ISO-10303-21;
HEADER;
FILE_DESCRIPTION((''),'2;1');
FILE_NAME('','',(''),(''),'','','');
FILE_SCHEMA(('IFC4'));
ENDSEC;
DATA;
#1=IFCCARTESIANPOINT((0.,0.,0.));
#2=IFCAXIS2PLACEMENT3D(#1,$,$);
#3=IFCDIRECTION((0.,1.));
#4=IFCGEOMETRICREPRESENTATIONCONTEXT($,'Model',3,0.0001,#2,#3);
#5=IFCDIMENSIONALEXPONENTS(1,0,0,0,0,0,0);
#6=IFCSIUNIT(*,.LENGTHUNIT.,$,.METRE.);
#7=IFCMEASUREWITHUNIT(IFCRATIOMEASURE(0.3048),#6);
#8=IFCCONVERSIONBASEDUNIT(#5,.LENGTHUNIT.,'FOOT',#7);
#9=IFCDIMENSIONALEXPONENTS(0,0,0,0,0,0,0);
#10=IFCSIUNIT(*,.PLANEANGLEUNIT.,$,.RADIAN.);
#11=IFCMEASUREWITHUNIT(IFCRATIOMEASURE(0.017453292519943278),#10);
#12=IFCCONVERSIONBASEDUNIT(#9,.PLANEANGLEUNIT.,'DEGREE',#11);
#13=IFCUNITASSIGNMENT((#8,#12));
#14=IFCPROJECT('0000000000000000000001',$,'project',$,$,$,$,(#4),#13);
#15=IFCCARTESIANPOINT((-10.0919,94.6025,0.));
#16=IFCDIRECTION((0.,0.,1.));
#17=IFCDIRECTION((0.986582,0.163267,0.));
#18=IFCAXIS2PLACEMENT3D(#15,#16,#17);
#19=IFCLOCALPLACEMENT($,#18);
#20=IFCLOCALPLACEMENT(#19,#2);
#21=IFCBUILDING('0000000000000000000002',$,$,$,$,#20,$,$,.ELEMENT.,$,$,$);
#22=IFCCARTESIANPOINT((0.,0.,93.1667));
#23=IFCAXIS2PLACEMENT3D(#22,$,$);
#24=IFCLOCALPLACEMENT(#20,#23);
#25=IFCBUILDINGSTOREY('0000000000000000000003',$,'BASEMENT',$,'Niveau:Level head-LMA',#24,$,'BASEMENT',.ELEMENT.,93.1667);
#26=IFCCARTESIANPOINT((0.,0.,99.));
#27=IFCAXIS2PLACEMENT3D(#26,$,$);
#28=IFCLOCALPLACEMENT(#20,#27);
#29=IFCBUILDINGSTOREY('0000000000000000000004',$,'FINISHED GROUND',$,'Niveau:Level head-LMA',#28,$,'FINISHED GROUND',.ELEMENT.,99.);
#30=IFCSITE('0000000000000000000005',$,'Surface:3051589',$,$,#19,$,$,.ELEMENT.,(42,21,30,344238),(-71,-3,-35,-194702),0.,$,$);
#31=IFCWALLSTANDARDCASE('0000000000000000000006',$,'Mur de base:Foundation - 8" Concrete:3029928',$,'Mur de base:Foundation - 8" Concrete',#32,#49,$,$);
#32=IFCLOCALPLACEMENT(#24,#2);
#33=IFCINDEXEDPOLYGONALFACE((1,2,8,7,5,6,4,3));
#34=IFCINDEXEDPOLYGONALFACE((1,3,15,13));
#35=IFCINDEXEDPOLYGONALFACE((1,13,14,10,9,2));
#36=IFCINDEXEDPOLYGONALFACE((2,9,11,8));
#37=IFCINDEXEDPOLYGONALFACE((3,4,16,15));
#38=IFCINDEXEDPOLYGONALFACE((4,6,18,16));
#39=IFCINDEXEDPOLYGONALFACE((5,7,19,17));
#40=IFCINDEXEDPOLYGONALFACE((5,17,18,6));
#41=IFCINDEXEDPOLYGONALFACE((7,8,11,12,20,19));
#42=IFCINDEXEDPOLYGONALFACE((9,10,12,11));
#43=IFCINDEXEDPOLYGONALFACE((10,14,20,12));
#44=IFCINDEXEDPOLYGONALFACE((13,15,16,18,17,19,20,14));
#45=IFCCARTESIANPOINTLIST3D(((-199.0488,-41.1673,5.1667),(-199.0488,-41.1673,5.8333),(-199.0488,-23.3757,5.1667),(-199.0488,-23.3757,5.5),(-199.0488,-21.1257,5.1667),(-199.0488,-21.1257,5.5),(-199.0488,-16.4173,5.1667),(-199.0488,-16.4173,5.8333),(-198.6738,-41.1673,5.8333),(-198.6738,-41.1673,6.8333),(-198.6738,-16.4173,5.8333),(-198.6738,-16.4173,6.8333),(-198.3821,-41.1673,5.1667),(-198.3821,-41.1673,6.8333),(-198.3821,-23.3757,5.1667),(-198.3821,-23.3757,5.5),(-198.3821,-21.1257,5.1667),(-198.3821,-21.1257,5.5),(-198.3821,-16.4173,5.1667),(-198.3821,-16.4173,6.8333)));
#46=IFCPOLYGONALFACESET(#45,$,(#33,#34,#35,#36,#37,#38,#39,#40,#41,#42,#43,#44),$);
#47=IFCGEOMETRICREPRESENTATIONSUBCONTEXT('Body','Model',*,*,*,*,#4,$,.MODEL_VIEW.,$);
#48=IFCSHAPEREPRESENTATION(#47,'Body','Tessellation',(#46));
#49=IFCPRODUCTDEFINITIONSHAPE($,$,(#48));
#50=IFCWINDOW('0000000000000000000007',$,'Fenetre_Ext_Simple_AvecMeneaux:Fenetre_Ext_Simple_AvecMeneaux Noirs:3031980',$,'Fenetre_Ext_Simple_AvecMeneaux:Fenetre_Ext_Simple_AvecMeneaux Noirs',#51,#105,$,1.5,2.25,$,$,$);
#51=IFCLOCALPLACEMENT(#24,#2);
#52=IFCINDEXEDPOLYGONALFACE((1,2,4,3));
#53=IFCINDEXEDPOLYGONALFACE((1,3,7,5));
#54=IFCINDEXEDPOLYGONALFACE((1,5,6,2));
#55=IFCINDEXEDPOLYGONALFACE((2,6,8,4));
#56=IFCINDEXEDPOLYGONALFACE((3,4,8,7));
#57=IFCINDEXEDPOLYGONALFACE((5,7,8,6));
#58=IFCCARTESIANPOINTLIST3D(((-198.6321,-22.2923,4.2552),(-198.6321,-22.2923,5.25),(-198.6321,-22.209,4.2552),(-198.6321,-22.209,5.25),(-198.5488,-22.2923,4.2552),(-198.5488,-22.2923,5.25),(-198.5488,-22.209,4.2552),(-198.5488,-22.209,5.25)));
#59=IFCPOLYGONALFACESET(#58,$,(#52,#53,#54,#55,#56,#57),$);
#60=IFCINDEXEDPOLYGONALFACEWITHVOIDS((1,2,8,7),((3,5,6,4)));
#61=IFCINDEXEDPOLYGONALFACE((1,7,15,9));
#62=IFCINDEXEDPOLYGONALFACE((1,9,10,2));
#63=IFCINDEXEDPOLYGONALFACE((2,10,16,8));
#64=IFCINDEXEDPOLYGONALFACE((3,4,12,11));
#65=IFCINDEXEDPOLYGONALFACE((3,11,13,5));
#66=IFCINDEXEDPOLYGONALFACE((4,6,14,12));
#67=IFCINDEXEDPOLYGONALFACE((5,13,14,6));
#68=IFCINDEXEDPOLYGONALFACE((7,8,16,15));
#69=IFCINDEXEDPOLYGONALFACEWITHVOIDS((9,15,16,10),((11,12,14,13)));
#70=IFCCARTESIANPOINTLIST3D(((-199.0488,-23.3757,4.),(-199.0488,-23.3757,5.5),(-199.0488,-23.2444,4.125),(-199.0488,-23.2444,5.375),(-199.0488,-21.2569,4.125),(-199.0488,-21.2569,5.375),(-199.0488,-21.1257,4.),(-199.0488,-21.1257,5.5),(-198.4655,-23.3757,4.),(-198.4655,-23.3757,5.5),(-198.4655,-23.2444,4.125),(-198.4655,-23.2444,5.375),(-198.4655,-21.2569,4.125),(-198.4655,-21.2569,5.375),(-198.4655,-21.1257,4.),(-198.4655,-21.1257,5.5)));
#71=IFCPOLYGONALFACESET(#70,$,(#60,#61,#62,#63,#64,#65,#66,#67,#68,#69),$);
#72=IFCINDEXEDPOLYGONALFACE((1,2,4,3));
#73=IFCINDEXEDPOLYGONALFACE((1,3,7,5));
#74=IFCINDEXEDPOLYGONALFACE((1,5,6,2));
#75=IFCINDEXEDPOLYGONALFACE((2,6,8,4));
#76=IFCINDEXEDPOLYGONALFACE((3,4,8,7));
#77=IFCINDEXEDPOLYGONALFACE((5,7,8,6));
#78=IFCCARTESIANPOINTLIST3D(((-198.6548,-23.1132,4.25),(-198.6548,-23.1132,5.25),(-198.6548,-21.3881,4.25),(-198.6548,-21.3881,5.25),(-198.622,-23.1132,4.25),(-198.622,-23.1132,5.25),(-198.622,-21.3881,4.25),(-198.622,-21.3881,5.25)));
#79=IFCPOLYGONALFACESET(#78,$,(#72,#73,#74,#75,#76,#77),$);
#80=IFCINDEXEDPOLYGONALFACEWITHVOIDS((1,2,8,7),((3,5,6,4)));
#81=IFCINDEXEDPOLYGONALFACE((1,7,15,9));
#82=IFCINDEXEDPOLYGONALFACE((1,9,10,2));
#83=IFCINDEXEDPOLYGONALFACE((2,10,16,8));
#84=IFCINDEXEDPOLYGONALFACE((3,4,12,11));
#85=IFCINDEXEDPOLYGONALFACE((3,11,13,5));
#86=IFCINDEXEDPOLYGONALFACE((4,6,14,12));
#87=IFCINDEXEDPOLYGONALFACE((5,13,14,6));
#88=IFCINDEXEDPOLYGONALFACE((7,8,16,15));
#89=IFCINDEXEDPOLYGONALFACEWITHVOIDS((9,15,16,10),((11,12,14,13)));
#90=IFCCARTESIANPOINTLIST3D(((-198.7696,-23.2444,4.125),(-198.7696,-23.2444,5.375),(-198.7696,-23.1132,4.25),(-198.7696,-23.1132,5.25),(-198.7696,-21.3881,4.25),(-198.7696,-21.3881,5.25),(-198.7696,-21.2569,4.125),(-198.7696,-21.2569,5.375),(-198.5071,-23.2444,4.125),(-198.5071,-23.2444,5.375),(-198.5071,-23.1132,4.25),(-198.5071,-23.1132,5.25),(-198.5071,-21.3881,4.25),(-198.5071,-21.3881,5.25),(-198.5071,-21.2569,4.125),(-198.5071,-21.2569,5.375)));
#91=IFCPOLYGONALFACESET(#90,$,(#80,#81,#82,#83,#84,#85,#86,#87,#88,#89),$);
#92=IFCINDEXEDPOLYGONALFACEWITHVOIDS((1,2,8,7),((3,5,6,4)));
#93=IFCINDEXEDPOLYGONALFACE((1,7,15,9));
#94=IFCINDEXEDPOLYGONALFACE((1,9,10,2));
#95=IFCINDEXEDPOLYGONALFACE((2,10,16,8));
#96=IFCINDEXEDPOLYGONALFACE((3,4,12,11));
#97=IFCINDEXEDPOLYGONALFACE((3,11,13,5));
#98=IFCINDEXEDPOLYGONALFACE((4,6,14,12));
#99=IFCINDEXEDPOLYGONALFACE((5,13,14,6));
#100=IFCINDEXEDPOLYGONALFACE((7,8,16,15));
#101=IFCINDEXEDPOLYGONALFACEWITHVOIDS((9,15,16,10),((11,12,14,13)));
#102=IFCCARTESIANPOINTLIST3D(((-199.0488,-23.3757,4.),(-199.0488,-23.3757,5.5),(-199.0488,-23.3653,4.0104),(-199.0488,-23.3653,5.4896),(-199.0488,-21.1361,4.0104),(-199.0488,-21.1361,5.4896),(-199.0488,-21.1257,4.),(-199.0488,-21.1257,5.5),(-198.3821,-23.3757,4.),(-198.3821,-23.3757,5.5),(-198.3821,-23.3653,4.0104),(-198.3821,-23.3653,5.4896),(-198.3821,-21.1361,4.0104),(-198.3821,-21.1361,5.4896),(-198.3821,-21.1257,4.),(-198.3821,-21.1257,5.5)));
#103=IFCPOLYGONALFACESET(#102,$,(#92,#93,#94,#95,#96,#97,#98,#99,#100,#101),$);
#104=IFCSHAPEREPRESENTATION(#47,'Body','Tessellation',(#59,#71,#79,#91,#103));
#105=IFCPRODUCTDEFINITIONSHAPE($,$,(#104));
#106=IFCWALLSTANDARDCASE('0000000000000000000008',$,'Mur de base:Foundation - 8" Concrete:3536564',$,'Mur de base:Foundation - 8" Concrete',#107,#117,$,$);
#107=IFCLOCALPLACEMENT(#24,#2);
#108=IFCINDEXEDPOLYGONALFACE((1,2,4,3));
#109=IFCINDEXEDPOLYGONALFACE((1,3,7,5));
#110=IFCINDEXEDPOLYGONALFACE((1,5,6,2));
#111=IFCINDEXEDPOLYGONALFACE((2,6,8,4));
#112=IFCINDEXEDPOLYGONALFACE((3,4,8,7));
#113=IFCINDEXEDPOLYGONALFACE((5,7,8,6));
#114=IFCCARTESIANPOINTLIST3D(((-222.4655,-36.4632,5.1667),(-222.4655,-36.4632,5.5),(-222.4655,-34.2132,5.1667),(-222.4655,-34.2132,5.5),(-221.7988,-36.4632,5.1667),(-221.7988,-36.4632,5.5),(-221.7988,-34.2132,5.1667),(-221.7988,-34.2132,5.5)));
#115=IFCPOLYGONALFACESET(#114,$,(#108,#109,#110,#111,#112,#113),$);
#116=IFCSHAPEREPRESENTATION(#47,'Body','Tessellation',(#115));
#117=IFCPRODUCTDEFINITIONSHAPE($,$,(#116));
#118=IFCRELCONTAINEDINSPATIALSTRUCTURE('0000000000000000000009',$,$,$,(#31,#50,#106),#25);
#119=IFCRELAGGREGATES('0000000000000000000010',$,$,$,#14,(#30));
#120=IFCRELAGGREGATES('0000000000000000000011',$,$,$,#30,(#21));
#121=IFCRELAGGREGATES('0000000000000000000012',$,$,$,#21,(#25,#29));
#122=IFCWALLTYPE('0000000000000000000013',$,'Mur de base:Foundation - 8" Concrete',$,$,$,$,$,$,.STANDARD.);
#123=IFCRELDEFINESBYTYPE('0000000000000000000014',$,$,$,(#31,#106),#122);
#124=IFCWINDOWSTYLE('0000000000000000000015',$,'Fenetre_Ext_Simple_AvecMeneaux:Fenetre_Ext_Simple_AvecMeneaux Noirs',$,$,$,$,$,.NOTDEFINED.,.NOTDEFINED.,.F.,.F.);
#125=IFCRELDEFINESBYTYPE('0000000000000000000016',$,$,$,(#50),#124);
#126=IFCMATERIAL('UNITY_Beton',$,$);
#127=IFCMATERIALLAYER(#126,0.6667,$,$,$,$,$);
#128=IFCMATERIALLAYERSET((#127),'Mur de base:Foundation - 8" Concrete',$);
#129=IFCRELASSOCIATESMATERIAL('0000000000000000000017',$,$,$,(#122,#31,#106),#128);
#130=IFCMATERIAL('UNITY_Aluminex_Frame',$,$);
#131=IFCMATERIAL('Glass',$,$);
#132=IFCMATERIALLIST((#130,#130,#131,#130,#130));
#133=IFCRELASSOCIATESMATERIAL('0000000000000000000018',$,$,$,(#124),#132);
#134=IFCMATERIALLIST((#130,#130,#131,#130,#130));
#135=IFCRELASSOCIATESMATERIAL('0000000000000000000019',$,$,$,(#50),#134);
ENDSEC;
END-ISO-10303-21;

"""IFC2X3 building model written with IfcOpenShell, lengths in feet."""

from ifc_helpers import new_model, entity, si_unit, converted_unit, direction, frame, frame_2d, origin, place, context, subcontext, project, spatial, polyline, rectangle, outline, extrude, clip, bounded_halfspace, source, transform, mapped, material, material_list, layer, layer_set, layer_usage, type_object, type_shapes, element, fill, save


model = new_model("IFC2X3")

# Units and contexts
model_context = context("Model", 3, precision=0.0001, world=origin(), true_north=direction((0.0, 1.0)))
body_context = subcontext(model_context, "Body", "Model", "MODEL_VIEW")
ifc_project = project(units=[converted_unit("LENGTHUNIT", "FOOT", entity("IfcRatioMeasure", 0.3048), si_unit("LENGTHUNIT", "METRE"), dimensions=[1, 0, 0, 0, 0, 0, 0]), converted_unit("PLANEANGLEUNIT", "DEGREE", entity("IfcRatioMeasure", 0.017453292519943278), si_unit("PLANEANGLEUNIT", "RADIAN"), dimensions=[0, 0, 0, 0, 0, 0, 0])], contexts=[model_context])

# Site, building, storey
site_placement = place(None, frame((-10.0919, 94.6025, 0.0), z_axis=(0.0, 0.0, 1.0), x_axis=(0.986582, 0.163267, 0.0)))
site = spatial("IfcSite", under=ifc_project, at=site_placement, Name="Surface:3051589", CompositionType="ELEMENT", RefLatitude=(42, 21, 30, 344238), RefLongitude=(-71, -3, -35, -194702), RefElevation=0.0)
building_placement = place(site_placement, origin())
building = spatial("IfcBuilding", under=site, at=building_placement, CompositionType="ELEMENT")
storey_1_placement = place(building_placement, frame((0.0, 0.0, 93.1667)))
storey_1 = spatial("IfcBuildingStorey", under=building, at=storey_1_placement, Name="BASEMENT", ObjectType="Niveau:Level head-LMA", LongName="BASEMENT", CompositionType="ELEMENT", Elevation=93.1667)

# Shared definitions
ifc_material_1 = material(Name="UNITY_Beton")
ifc_layer = layer(ifc_material_1, 0.6667)
ifc_layer_set = layer_set([ifc_layer], Name="Mur de base:Foundation - 8\" Concrete")
wall_type = type_object("IfcWallType", Name="Mur de base:Foundation - 8\" Concrete", PredefinedType="STANDARD", material=ifc_layer_set)
ifc_material_2 = material(Name="UNITY_Aluminex_Frame")
ifc_material_3 = material(Name="Glass")
ifc_material_list_1 = material_list([ifc_material_2, ifc_material_2, ifc_material_3, ifc_material_2, ifc_material_2])
window_style_1 = type_object("IfcWindowStyle", Name="Fenetre_Ext_Simple_AvecMeneaux:Fenetre_Ext_Simple_AvecMeneaux Noirs", ConstructionType="NOTDEFINED", OperationType="NOTDEFINED", ParameterTakesPrecedence=False, Sizeable=False, material=ifc_material_list_1)
shared_shape_1 = source(origin(), body_context, "Body", "SweptSolid", [
    extrude(rectangle(XDim=0.0833, YDim=0.0833, at=frame_2d((0.0, 0.0), x_axis=(1.0, 0.0))), frame((1.125, 0.4583, 0.2552), z_axis=(0.0, 0.0, 1.0), x_axis=(0.0, -1.0, 0.0)), (0.0, 0.0, 1.0), 0.9948),
    extrude(outline(polyline([(-0.75, -1.125), (0.75, -1.125), (0.75, 1.125), (-0.75, 1.125), (-0.75, -1.125)]), holes=[polyline([(-0.625, 0.9938), (0.625, 0.9938), (0.625, -0.9938), (-0.625, -0.9938), (-0.625, 0.9938)])]), frame((1.125, 0.0, 0.75), z_axis=(0.0, 1.0, 0.0), x_axis=(0.0, 0.0, -1.0)), (0.0, 0.0, 1.0), 0.5833),
    extrude(rectangle(XDim=0.0328, YDim=1.7251, at=frame_2d((0.0, 0.0), x_axis=(1.0, 0.0))), frame((1.125, 0.4104, 0.25), z_axis=(0.0, 0.0, 1.0), x_axis=(0.0, 1.0, 0.0)), (0.0, 0.0, 1.0), 1.0),
    extrude(outline(polyline([(-0.9938, -0.625), (0.9938, -0.625), (0.9938, 0.625), (-0.9938, 0.625), (-0.9938, -0.625)]), holes=[polyline([(-0.8625, -0.5), (-0.8625, 0.5), (0.8625, 0.5), (0.8625, -0.5), (-0.8625, -0.5)])]), frame((1.125, 0.2792, 0.75), z_axis=(0.0, 1.0, 0.0), x_axis=(1.0, 0.0, 0.0)), (0.0, 0.0, 1.0), 0.2625),
    extrude(outline(polyline([(-1.125, -0.75), (1.125, -0.75), (1.125, 0.75), (-1.125, 0.75), (-1.125, -0.75)]), holes=[polyline([(1.1146, -0.7396), (-1.1146, -0.7396), (-1.1146, 0.7396), (1.1146, 0.7396), (1.1146, -0.7396)])]), frame((1.125, 0.0, 0.75), z_axis=(0.0, 1.0, 0.0), x_axis=(1.0, 0.0, 0.0)), (0.0, 0.0, 1.0), 0.6667),
])
type_shapes(window_style_1, [shared_shape_1])

# Shared definitions
storey_2_placement = place(building_placement, frame((0.0, 0.0, 99.0)))
storey_2 = spatial("IfcBuildingStorey", under=building, at=storey_2_placement, Name="FINISHED GROUND", ObjectType="Niveau:Level head-LMA", LongName="FINISHED GROUND", CompositionType="ELEMENT", Elevation=99.0)

# Wall, opening, window
ifc_layer_usage_1 = layer_usage(ifc_layer_set, "AXIS2", "POSITIVE", -0.3333)
wall_1_placement = place(storey_1_placement, frame((-198.7155, -41.1673, 5.1667), z_axis=(0.0, 0.0, 1.0), x_axis=(0.0, 1.0, 0.0)))
wall_1 = element("IfcWallStandardCase", 1, at=wall_1_placement, inside=storey_1, type_object=wall_type, material=ifc_layer_usage_1, Name="Mur de base:Foundation - 8\" Concrete:3029928", ObjectType="Mur de base:Foundation - 8\" Concrete", context=body_context, shape_type="Clipping", body=[
    clip(clip(extrude(rectangle(XDim=24.75, YDim=0.6667, at=frame_2d((12.375, 0.0), x_axis=(-1.0, 0.0))), origin(), (0.0, 0.0, 1.0), 1.6667), bounded_halfspace(frame((0.0, -0.0416, 0.6667), z_axis=(0.0, 0.0, -1.0), x_axis=(-1.0, 0.0, 0.0)), True, frame((0.0, -0.0416, 0.6667), z_axis=(0.0, 0.0, -1.0), x_axis=(-1.0, 0.0, 0.0)), polyline([(0.0, 0.0), (0.0, 0.375), (-24.75, 0.375), (-24.75, 0.0), (0.0, 0.0)]))), bounded_halfspace(frame((24.75, -0.0416, 0.6667), z_axis=(0.0, -1.0, 0.0), x_axis=(0.0, 0.0, 1.0)), True, frame((24.75, -0.0416, 0.6667), z_axis=(0.0, -1.0, 0.0), x_axis=(0.0, 0.0, 1.0)), polyline([(0.0, 0.0), (1.0, 0.0), (1.0, 24.75), (0.0, 24.75), (0.0, 0.0)]))),
])
opening_1_placement = place(wall_1_placement, frame((20.0417, 0.3333, -1.1667)))
opening_1 = element("IfcOpeningElement", 2, at=opening_1_placement, cuts=wall_1, ObjectType="Opening", context=body_context, shape_type="SweptSolid", body=[
    extrude(rectangle(XDim=1.5, YDim=2.25, at=frame_2d((0.75, 1.125), x_axis=(1.0, 0.0))), frame((0.0, 0.0, 0.0), z_axis=(0.0, -1.0, 0.0), x_axis=(0.0, 0.0, 1.0)), (0.0, 0.0, 1.0), 0.6667),
])
ifc_material_list_2 = material_list([ifc_material_2, ifc_material_2, ifc_material_3, ifc_material_2, ifc_material_2])
window_1_placement = place(opening_1_placement, frame((0.0, 0.0, 0.0), z_axis=(0.0, 0.0, 1.0), x_axis=(-1.0, 0.0, 0.0)))
window_1 = element("IfcWindow", 3, at=window_1_placement, inside=storey_1, type_object=window_style_1, material=ifc_material_list_2, Name="Fenetre_Ext_Simple_AvecMeneaux:Fenetre_Ext_Simple_AvecMeneaux Noirs:3031980", ObjectType="Fenetre_Ext_Simple_AvecMeneaux:Fenetre_Ext_Simple_AvecMeneaux Noirs", OverallHeight=1.5, OverallWidth=2.25, context=body_context, shape_type="MappedRepresentation", body=[
    mapped(shared_shape_1, transform((0.0, 0.0, 0.0), scale=1.0)),
])
fill(opening_1, window_1)

# Wall
ifc_layer_usage_2 = layer_usage(ifc_layer_set, "AXIS2", "NEGATIVE", 0.3333)
wall_2_placement = place(storey_1_placement, frame((-222.1321, -36.4632, 5.1667), z_axis=(0.0, 0.0, 1.0), x_axis=(0.0, 1.0, 0.0)))
element("IfcWallStandardCase", 4, at=wall_2_placement, inside=storey_1, type_object=wall_type, material=ifc_layer_usage_2, Name="Mur de base:Foundation - 8\" Concrete:3536564", ObjectType="Mur de base:Foundation - 8\" Concrete", context=body_context, shape_type="SweptSolid", body=[
    extrude(rectangle(XDim=0.6667, YDim=2.25, at=frame_2d((0.0, 0.0), x_axis=(1.0, 0.0))), frame((1.125, 0.0, 0.0), z_axis=(0.0, 0.0, 1.0), x_axis=(0.0, 1.0, 0.0)), (0.0, 0.0, 1.0), 0.3333),
])

save(model, "model.ifc")
